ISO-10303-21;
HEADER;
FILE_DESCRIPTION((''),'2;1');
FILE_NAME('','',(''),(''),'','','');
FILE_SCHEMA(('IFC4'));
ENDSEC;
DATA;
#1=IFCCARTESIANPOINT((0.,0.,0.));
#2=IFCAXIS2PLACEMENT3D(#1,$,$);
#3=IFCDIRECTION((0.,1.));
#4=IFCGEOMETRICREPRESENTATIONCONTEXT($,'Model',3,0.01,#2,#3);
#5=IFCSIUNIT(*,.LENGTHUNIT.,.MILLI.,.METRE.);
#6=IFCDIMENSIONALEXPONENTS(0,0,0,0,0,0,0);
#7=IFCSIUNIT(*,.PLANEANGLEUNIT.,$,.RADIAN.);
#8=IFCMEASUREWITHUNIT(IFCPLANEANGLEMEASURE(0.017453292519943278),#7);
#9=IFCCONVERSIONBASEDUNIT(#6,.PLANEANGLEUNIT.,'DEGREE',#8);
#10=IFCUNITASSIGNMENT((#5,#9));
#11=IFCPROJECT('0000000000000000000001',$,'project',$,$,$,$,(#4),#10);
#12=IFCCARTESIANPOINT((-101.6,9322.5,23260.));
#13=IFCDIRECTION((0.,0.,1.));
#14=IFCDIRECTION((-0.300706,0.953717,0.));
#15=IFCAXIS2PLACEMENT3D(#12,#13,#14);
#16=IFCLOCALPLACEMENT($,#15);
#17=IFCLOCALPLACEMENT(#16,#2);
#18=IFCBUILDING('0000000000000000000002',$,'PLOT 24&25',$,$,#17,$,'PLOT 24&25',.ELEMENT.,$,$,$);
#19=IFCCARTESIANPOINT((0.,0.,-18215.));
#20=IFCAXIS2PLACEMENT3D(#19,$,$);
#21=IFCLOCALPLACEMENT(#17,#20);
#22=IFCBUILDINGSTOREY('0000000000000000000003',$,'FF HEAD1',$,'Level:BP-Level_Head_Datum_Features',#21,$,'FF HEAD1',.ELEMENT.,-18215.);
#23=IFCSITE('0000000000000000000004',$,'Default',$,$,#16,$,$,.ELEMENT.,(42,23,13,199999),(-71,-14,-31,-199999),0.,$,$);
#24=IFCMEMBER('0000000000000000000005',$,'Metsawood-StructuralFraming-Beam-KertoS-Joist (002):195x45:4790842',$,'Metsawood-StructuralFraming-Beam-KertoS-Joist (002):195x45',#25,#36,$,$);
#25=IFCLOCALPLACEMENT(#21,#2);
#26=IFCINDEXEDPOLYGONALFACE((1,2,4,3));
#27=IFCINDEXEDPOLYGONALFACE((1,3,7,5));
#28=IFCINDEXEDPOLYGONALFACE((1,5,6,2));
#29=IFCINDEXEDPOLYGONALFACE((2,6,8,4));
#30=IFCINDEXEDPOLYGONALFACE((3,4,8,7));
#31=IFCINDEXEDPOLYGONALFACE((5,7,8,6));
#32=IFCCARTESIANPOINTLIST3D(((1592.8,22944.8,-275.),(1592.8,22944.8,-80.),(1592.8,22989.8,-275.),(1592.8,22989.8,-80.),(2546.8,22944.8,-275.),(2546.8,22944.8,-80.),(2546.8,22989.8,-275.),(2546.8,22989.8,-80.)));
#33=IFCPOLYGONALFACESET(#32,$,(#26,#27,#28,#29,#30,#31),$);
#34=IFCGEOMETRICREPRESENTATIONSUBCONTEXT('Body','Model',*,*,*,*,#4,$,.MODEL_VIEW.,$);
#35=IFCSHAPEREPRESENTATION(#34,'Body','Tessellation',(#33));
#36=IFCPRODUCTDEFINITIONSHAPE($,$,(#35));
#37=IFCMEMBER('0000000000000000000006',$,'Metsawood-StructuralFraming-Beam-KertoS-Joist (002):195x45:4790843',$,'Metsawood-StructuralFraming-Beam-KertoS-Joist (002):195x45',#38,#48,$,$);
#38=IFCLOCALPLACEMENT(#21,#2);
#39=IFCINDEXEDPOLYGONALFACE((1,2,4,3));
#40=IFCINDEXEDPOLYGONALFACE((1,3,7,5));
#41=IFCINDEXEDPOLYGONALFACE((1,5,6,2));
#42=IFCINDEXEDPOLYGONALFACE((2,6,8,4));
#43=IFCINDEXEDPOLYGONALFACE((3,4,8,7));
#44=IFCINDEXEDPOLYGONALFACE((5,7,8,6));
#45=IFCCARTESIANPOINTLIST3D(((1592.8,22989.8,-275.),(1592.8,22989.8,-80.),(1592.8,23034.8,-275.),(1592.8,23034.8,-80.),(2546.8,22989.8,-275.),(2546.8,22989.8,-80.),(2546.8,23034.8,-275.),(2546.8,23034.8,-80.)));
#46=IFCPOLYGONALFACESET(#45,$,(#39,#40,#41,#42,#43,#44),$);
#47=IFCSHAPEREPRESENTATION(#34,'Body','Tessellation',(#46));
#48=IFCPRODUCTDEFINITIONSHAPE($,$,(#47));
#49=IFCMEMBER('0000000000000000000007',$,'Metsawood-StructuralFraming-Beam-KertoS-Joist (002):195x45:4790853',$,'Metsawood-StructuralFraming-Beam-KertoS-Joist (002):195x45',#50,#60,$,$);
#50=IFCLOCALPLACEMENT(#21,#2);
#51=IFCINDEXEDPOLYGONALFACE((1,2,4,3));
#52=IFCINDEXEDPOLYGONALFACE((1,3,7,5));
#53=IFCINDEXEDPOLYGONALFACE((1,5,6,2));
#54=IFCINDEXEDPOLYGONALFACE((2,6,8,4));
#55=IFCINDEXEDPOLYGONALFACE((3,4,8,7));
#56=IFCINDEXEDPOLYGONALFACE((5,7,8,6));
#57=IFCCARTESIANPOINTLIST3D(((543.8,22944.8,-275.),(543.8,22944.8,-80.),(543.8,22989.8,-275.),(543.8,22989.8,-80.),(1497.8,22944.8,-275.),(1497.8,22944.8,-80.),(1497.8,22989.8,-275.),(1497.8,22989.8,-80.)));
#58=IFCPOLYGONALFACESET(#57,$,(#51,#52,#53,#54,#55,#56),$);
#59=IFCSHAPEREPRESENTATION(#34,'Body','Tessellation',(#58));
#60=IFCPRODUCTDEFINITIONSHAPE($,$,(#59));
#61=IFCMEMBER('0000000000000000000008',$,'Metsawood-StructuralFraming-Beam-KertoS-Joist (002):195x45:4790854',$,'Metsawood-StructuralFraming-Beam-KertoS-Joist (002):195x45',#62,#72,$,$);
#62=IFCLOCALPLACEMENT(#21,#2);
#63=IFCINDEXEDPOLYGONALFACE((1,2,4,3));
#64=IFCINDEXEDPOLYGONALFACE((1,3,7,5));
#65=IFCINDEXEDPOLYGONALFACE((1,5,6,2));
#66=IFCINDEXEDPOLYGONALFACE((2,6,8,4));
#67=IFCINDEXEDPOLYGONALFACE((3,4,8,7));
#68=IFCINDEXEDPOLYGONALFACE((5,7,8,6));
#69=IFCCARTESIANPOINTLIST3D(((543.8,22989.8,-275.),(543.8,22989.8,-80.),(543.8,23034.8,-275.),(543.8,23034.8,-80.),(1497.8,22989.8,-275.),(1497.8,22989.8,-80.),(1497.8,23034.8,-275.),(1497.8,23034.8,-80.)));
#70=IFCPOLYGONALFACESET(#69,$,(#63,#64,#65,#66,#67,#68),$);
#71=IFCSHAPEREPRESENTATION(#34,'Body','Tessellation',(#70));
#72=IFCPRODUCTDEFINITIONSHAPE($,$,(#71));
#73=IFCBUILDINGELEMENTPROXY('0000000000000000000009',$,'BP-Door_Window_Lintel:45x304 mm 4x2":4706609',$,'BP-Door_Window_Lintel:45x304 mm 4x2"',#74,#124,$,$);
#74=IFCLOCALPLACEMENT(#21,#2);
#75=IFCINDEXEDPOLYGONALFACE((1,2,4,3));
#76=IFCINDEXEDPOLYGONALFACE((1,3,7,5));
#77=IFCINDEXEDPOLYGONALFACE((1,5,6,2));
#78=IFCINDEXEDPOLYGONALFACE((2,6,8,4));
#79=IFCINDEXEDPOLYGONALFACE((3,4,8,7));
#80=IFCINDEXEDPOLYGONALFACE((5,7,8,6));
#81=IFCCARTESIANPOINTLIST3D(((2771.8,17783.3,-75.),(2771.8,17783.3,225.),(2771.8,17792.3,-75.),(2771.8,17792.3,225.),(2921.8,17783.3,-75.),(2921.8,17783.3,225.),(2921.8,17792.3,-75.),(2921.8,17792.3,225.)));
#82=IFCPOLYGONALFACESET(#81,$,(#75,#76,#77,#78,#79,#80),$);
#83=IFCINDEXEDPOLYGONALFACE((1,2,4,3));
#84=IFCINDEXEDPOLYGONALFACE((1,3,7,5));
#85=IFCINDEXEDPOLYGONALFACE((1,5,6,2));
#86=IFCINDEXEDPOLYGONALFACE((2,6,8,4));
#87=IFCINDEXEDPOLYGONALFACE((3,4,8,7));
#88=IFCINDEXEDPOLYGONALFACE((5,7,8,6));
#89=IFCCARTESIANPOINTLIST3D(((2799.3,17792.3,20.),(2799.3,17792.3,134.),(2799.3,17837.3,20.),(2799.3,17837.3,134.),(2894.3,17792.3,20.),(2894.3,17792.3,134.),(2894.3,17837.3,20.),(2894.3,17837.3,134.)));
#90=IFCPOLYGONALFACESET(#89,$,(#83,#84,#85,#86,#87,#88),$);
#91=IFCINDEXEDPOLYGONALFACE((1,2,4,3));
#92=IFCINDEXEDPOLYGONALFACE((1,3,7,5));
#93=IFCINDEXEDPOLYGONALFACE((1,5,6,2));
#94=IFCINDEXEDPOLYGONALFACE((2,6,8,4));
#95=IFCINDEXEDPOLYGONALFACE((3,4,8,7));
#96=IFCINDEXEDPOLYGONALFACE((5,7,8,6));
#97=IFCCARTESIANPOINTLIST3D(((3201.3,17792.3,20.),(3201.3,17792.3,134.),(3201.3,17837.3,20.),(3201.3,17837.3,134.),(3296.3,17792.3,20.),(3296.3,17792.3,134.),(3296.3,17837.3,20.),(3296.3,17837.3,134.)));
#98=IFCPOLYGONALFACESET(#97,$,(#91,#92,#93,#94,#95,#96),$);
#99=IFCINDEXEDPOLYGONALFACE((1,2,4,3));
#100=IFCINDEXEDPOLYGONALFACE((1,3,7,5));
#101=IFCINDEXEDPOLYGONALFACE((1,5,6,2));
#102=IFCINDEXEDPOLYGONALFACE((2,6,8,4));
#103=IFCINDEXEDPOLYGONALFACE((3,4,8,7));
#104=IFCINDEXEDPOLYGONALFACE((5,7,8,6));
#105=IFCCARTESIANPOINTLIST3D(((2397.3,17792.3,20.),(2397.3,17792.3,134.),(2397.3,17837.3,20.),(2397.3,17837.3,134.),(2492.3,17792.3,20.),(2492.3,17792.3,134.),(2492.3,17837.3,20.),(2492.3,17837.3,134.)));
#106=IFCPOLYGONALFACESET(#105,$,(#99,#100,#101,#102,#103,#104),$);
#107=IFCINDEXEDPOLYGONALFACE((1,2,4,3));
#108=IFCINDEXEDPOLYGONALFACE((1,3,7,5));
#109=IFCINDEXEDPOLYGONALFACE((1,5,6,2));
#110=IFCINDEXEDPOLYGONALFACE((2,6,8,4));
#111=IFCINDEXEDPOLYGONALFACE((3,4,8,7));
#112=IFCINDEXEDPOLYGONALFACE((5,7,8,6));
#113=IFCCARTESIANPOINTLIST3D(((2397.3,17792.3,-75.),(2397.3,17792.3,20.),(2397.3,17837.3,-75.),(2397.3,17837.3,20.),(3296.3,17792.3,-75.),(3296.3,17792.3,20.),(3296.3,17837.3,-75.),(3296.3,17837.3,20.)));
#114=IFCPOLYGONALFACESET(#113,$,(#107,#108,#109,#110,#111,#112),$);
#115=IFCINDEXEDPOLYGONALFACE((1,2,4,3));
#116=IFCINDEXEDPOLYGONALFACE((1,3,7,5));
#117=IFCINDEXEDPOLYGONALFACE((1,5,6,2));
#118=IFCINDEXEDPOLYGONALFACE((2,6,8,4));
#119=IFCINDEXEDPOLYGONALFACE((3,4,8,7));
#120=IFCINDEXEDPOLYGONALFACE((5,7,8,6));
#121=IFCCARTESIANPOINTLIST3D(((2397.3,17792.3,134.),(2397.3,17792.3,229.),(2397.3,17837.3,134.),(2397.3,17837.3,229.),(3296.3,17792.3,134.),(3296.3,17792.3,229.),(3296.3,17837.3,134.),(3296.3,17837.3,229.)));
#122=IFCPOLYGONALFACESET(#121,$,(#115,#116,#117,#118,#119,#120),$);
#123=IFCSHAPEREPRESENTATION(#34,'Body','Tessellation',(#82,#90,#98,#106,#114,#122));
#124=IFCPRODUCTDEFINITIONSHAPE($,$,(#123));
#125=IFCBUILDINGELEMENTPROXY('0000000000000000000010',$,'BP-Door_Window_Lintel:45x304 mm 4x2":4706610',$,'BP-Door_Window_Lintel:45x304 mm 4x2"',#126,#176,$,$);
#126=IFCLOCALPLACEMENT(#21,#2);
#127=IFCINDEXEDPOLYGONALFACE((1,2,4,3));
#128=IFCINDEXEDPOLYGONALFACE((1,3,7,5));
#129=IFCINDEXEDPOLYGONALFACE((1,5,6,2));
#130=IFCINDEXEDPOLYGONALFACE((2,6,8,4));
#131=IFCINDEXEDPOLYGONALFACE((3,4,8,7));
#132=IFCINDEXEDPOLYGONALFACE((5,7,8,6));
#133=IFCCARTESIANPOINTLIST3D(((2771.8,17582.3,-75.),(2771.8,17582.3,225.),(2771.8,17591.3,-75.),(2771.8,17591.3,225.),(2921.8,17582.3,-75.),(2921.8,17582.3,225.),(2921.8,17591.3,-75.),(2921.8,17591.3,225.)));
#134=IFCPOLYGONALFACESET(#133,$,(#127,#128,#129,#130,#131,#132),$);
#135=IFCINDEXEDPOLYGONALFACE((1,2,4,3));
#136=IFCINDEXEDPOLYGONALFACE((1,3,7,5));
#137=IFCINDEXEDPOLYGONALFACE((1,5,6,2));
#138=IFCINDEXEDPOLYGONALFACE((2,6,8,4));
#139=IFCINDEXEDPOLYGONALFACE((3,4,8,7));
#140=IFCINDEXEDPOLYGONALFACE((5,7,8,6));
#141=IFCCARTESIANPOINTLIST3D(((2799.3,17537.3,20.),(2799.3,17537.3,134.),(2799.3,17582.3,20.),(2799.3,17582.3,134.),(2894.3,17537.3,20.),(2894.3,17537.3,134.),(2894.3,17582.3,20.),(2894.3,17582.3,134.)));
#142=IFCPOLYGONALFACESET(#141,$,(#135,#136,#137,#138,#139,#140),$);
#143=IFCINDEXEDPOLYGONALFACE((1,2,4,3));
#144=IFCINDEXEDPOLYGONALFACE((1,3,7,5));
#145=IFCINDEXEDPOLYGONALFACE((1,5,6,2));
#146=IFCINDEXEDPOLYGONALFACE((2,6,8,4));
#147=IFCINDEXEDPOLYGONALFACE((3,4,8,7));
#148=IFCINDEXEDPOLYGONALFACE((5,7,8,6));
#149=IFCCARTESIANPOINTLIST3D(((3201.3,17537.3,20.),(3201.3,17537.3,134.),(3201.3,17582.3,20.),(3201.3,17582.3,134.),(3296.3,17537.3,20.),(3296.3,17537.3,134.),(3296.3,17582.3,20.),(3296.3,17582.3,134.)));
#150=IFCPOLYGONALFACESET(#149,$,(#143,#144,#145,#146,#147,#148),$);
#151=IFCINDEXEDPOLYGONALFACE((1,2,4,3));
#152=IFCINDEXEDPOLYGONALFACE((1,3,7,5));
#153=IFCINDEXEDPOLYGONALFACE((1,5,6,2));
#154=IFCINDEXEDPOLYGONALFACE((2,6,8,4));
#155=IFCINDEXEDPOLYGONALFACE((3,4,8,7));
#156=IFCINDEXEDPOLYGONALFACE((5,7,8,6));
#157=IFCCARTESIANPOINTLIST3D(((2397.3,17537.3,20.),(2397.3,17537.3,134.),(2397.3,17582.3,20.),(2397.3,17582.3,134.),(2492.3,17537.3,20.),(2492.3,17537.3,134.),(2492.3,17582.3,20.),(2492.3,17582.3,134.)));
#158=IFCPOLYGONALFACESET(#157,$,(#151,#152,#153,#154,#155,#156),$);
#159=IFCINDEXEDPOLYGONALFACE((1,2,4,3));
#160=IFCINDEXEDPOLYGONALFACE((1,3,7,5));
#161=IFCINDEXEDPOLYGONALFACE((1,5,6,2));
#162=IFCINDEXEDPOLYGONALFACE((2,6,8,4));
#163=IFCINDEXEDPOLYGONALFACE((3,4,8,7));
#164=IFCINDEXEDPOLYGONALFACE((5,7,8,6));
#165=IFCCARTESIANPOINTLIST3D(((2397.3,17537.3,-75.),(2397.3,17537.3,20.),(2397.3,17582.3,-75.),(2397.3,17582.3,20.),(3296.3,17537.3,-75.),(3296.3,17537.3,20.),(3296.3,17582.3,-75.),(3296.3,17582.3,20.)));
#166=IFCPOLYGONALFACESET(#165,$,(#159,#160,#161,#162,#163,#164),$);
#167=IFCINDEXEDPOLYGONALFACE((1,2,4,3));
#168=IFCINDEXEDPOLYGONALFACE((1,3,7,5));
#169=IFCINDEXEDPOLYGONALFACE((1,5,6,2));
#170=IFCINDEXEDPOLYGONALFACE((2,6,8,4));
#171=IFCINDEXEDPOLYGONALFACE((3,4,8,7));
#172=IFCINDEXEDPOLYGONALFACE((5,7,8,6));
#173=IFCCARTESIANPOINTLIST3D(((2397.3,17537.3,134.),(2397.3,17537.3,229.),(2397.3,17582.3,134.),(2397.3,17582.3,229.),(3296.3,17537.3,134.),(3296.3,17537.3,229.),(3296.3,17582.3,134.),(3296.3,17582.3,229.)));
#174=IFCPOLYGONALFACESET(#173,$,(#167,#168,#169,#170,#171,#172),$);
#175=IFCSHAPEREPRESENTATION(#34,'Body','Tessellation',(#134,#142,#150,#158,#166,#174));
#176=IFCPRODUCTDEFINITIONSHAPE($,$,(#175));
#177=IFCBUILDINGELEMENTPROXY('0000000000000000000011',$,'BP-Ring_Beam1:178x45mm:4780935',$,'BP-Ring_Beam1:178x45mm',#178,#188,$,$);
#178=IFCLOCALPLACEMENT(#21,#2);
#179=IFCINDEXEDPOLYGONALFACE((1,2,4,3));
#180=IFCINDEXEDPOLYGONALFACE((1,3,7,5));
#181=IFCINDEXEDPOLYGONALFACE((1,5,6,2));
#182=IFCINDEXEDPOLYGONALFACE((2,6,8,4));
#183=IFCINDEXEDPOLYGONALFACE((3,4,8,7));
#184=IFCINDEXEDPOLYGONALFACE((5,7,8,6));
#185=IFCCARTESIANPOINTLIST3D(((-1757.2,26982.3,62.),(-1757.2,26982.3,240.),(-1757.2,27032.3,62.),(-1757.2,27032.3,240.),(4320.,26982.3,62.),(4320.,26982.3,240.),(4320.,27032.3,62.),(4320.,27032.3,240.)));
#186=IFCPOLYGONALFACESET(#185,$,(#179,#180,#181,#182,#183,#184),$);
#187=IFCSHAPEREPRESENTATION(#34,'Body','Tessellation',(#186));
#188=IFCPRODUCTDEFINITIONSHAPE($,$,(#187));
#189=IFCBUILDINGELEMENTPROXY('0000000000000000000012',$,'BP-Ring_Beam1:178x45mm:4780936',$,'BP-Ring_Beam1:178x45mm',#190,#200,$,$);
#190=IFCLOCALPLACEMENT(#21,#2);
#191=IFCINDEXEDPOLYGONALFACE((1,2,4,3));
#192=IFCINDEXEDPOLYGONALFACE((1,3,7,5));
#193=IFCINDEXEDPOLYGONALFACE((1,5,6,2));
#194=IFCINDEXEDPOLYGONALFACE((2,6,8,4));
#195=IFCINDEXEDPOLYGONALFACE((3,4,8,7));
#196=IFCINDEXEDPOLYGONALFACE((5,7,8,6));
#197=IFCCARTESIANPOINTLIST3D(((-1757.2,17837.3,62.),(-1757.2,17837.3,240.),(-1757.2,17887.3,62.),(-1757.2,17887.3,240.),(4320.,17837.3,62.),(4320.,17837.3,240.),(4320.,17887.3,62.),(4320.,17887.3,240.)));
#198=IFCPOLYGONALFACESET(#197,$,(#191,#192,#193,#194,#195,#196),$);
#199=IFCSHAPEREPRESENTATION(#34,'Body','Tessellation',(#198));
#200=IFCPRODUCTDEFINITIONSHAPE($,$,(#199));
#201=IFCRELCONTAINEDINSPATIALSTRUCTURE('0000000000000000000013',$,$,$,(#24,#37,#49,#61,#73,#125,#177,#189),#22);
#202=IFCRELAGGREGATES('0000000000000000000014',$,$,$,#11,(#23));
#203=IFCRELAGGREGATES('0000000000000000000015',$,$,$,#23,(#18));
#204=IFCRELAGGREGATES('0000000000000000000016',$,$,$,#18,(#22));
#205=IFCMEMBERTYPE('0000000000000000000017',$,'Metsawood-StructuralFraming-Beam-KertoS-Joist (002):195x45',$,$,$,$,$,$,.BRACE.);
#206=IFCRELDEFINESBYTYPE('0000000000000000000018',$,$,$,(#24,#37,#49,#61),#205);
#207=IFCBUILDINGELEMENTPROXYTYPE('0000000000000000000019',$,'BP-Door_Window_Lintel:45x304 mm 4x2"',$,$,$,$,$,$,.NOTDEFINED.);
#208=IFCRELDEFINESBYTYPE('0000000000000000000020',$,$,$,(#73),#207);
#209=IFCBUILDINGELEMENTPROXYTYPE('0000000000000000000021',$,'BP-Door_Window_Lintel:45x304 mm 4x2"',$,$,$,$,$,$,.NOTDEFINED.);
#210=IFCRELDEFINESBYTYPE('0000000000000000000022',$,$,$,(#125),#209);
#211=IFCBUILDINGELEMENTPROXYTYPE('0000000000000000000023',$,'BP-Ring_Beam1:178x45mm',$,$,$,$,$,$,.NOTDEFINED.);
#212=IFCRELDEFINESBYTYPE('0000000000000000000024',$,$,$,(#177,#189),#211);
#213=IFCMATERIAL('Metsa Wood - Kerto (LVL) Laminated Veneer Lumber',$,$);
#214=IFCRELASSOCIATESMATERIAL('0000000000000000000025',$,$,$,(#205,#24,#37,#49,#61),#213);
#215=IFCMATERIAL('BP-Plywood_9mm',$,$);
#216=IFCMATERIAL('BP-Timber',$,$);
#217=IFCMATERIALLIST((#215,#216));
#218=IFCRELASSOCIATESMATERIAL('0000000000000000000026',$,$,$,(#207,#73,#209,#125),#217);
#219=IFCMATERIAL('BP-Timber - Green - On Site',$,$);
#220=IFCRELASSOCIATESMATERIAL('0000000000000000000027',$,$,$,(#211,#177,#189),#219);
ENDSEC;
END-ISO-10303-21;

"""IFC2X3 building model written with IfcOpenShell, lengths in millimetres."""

from ifc_helpers import new_model, entity, si_unit, converted_unit, direction, frame, frame_2d, origin, origin_2d_with_axis, place, context, subcontext, project, spatial, rectangle, extrude, source, transform, mapped, material, material_list, type_object, type_shapes, element, save


model = new_model("IFC2X3")

# Units and contexts
model_context = context("Model", 3, precision=0.01, world=origin(), true_north=direction((0.0, 1.0)))
body_context = subcontext(model_context, "Body", "Model", "MODEL_VIEW")
ifc_project = project(units=[si_unit("LENGTHUNIT", "METRE", prefix="MILLI"), converted_unit("PLANEANGLEUNIT", "DEGREE", entity("IfcPlaneAngleMeasure", 0.017453292519943278), si_unit("PLANEANGLEUNIT", "RADIAN"), dimensions=[0, 0, 0, 0, 0, 0, 0])], contexts=[model_context])

# Site, building, storey
site_placement = place(None, frame((-101.6, 9322.5, 23260.0), z_axis=(0.0, 0.0, 1.0), x_axis=(-0.300706, 0.953717, 0.0)))
site = spatial("IfcSite", under=ifc_project, at=site_placement, Name="Default", CompositionType="ELEMENT", RefLatitude=(42, 23, 13, 199999), RefLongitude=(-71, -14, -31, -199999), RefElevation=0.0)
building_placement = place(site_placement, origin())
building = spatial("IfcBuilding", under=site, at=building_placement, Name="PLOT 24&25", LongName="PLOT 24&25", CompositionType="ELEMENT")
storey_placement = place(building_placement, frame((0.0, 0.0, -18215.0)))
storey = spatial("IfcBuildingStorey", under=building, at=storey_placement, Name="FF HEAD1", ObjectType="Level:BP-Level_Head_Datum_Features", LongName="FF HEAD1", CompositionType="ELEMENT", Elevation=-18215.0)

# Members
ifc_material_1 = material(Name="Metsa Wood - Kerto (LVL) Laminated Veneer Lumber")
member_type = type_object("IfcMemberType", Name="Metsawood-StructuralFraming-Beam-KertoS-Joist (002):195x45", PredefinedType="BRACE", material=ifc_material_1)
shared_shape_1 = source(origin(), body_context, "Body", "SweptSolid", [
    extrude(rectangle(XDim=195.0, YDim=45.0, at=frame_2d((0.0, 0.0), x_axis=(1.0, 0.0))), frame((-477.0, 0.0, 0.0), z_axis=(1.0, 0.0, 0.0), x_axis=(0.0, 0.0, -1.0)), (0.0, 0.0, 1.0), 954.0),
])
type_shapes(member_type, [shared_shape_1])
for number, where, name in (
    (1, (2069.8, 22967.3, -177.5), "Metsawood-StructuralFraming-Beam-KertoS-Joist (002):195x45:4790842"),
    (2, (2069.8, 23012.3, -177.5), "Metsawood-StructuralFraming-Beam-KertoS-Joist (002):195x45:4790843"),
    (3, (1020.8, 22967.3, -177.5), "Metsawood-StructuralFraming-Beam-KertoS-Joist (002):195x45:4790853"),
    (4, (1020.8, 23012.3, -177.5), "Metsawood-StructuralFraming-Beam-KertoS-Joist (002):195x45:4790854"),
):
    element("IfcMember", number, at=place(storey_placement, frame(where)), inside=storey, type_object=member_type, material=ifc_material_1, Name=name, ObjectType="Metsawood-StructuralFraming-Beam-KertoS-Joist (002):195x45", context=body_context, shape_type="MappedRepresentation", body=[
        mapped(shared_shape_1, transform((0.0, 0.0, 0.0), scale=1.0)),
    ])

# Building element proxies
ifc_material_2 = material(Name="BP-Timber")
ifc_material_3 = material(Name="BP-Plywood_9mm")
ifc_material_list_1 = material_list([ifc_material_3, ifc_material_2])
building_element_proxy_type_1 = type_object("IfcBuildingElementProxyType", Name="BP-Door_Window_Lintel:45x304 mm 4x2\"", PredefinedType="NOTDEFINED", material=ifc_material_list_1)
shared_shape_2 = source(origin(), body_context, "Body", "SweptSolid", [
    extrude(rectangle(XDim=150.0, YDim=9.0, at=origin_2d_with_axis()), frame((746.4, -27.0, 0.0), z_axis=(0.0, 0.0, 1.0), x_axis=(-1.0, 0.0, 0.0)), (0.0, 0.0, 1.0), 300.0),
    extrude(rectangle(XDim=95.0, YDim=45.0, at=origin_2d_with_axis()), frame((746.4, 0.0, 95.0), z_axis=(0.0, 0.0, 1.0), x_axis=(-1.0, 0.0, 0.0)), (0.0, 0.0, 1.0), 114.0),
    extrude(rectangle(XDim=45.0, YDim=95.0, at=origin_2d_with_axis()), frame((1148.4, 0.0, 95.0), z_axis=(0.0, 0.0, 1.0), x_axis=(0.0, -1.0, 0.0)), (0.0, 0.0, 1.0), 114.0),
    extrude(rectangle(XDim=95.0, YDim=45.0, at=frame_2d((0.0, 0.0), x_axis=(1.0, 0.0))), frame((344.4, 0.0, 95.0), z_axis=(0.0, 0.0, 1.0), x_axis=(-1.0, 0.0, 0.0)), (0.0, 0.0, 1.0), 114.0),
    extrude(rectangle(XDim=899.0, YDim=45.0, at=frame_2d((0.0, 0.0), x_axis=(1.0, 0.0))), frame((746.4, 0.0, 0.0)), (0.0, 0.0, 1.0), 95.0),
    extrude(rectangle(XDim=899.0, YDim=45.0, at=frame_2d((0.0, 0.0), x_axis=(1.0, 0.0))), frame((746.4, 0.0, 209.0)), (0.0, 0.0, 1.0), 95.0),
])
type_shapes(building_element_proxy_type_1, [shared_shape_2])
proxy_1_placement = place(storey_placement, frame((2100.4, 17814.8, -75.0)))
element("IfcBuildingElementProxy", 5, at=proxy_1_placement, inside=storey, type_object=building_element_proxy_type_1, material=ifc_material_list_1, Name="BP-Door_Window_Lintel:45x304 mm 4x2\":4706609", ObjectType="BP-Door_Window_Lintel:45x304 mm 4x2\"", context=body_context, shape_type="MappedRepresentation", body=[
    mapped(shared_shape_2, transform((0.0, 0.0, 0.0), scale=1.0)),
])
building_element_proxy_type_2 = type_object("IfcBuildingElementProxyType", Name="BP-Door_Window_Lintel:45x304 mm 4x2\"", PredefinedType="NOTDEFINED", material=ifc_material_list_1)
shared_shape_3 = source(origin(), body_context, "Body", "SweptSolid", [
    extrude(rectangle(XDim=9.0, YDim=150.0, at=origin_2d_with_axis()), frame((746.4, 27.0, 0.0), z_axis=(0.0, 0.0, 1.0), x_axis=(0.0, 1.0, 0.0)), (0.0, 0.0, 1.0), 300.0),
    extrude(rectangle(XDim=45.0, YDim=95.0, at=origin_2d_with_axis()), frame((746.4, 0.0, 95.0), z_axis=(0.0, 0.0, 1.0), x_axis=(0.0, 1.0, 0.0)), (0.0, 0.0, 1.0), 114.0),
    extrude(rectangle(XDim=95.0, YDim=45.0, at=origin_2d_with_axis()), frame((1148.4, 0.0, 95.0)), (0.0, 0.0, 1.0), 114.0),
    extrude(rectangle(XDim=45.0, YDim=95.0, at=frame_2d((0.0, 0.0), x_axis=(1.0, 0.0))), frame((344.4, 0.0, 95.0), z_axis=(0.0, 0.0, 1.0), x_axis=(0.0, 1.0, 0.0)), (0.0, 0.0, 1.0), 114.0),
    extrude(rectangle(XDim=45.0, YDim=899.0, at=origin_2d_with_axis()), frame((746.4, 0.0, 0.0), z_axis=(0.0, 0.0, 1.0), x_axis=(0.0, -1.0, 0.0)), (0.0, 0.0, 1.0), 95.0),
    extrude(rectangle(XDim=45.0, YDim=899.0, at=origin_2d_with_axis()), frame((746.4, 0.0, 209.0), z_axis=(0.0, 0.0, 1.0), x_axis=(0.0, -1.0, 0.0)), (0.0, 0.0, 1.0), 95.0),
])
type_shapes(building_element_proxy_type_2, [shared_shape_3])
proxy_2_placement = place(storey_placement, frame((2100.4, 17559.8, -75.0)))
element("IfcBuildingElementProxy", 6, at=proxy_2_placement, inside=storey, type_object=building_element_proxy_type_2, material=ifc_material_list_1, Name="BP-Door_Window_Lintel:45x304 mm 4x2\":4706610", ObjectType="BP-Door_Window_Lintel:45x304 mm 4x2\"", context=body_context, shape_type="MappedRepresentation", body=[
    mapped(shared_shape_3, transform((0.0, 0.0, 0.0), scale=1.0)),
])
ifc_material_4 = material(Name="BP-Timber - Green - On Site")
building_element_proxy_type_3 = type_object("IfcBuildingElementProxyType", Name="BP-Ring_Beam1:178x45mm", PredefinedType="NOTDEFINED", material=ifc_material_4)
shared_shape_4 = source(origin(), body_context, "Body", "SweptSolid", [
    extrude(rectangle(XDim=6077.2, YDim=50.0, at=origin_2d_with_axis()), frame((0.0, -25.0, -178.0), z_axis=(0.0, 0.0, 1.0), x_axis=(-1.0, 0.0, 0.0)), (0.0, 0.0, 1.0), 178.0),
])
type_shapes(building_element_proxy_type_3, [shared_shape_4])
for number, where, name in (
    (7, (1281.4, 27032.3, 240.0), "BP-Ring_Beam1:178x45mm:4780935"),
    (8, (1281.4, 17887.3, 240.0), "BP-Ring_Beam1:178x45mm:4780936"),
):
    element("IfcBuildingElementProxy", number, at=place(storey_placement, frame(where)), inside=storey, type_object=building_element_proxy_type_3, material=ifc_material_4, Name=name, ObjectType="BP-Ring_Beam1:178x45mm", context=body_context, shape_type="MappedRepresentation", body=[
        mapped(shared_shape_4, transform((0.0, 0.0, 0.0), scale=1.0)),
    ])

save(model, "model.ifc")
